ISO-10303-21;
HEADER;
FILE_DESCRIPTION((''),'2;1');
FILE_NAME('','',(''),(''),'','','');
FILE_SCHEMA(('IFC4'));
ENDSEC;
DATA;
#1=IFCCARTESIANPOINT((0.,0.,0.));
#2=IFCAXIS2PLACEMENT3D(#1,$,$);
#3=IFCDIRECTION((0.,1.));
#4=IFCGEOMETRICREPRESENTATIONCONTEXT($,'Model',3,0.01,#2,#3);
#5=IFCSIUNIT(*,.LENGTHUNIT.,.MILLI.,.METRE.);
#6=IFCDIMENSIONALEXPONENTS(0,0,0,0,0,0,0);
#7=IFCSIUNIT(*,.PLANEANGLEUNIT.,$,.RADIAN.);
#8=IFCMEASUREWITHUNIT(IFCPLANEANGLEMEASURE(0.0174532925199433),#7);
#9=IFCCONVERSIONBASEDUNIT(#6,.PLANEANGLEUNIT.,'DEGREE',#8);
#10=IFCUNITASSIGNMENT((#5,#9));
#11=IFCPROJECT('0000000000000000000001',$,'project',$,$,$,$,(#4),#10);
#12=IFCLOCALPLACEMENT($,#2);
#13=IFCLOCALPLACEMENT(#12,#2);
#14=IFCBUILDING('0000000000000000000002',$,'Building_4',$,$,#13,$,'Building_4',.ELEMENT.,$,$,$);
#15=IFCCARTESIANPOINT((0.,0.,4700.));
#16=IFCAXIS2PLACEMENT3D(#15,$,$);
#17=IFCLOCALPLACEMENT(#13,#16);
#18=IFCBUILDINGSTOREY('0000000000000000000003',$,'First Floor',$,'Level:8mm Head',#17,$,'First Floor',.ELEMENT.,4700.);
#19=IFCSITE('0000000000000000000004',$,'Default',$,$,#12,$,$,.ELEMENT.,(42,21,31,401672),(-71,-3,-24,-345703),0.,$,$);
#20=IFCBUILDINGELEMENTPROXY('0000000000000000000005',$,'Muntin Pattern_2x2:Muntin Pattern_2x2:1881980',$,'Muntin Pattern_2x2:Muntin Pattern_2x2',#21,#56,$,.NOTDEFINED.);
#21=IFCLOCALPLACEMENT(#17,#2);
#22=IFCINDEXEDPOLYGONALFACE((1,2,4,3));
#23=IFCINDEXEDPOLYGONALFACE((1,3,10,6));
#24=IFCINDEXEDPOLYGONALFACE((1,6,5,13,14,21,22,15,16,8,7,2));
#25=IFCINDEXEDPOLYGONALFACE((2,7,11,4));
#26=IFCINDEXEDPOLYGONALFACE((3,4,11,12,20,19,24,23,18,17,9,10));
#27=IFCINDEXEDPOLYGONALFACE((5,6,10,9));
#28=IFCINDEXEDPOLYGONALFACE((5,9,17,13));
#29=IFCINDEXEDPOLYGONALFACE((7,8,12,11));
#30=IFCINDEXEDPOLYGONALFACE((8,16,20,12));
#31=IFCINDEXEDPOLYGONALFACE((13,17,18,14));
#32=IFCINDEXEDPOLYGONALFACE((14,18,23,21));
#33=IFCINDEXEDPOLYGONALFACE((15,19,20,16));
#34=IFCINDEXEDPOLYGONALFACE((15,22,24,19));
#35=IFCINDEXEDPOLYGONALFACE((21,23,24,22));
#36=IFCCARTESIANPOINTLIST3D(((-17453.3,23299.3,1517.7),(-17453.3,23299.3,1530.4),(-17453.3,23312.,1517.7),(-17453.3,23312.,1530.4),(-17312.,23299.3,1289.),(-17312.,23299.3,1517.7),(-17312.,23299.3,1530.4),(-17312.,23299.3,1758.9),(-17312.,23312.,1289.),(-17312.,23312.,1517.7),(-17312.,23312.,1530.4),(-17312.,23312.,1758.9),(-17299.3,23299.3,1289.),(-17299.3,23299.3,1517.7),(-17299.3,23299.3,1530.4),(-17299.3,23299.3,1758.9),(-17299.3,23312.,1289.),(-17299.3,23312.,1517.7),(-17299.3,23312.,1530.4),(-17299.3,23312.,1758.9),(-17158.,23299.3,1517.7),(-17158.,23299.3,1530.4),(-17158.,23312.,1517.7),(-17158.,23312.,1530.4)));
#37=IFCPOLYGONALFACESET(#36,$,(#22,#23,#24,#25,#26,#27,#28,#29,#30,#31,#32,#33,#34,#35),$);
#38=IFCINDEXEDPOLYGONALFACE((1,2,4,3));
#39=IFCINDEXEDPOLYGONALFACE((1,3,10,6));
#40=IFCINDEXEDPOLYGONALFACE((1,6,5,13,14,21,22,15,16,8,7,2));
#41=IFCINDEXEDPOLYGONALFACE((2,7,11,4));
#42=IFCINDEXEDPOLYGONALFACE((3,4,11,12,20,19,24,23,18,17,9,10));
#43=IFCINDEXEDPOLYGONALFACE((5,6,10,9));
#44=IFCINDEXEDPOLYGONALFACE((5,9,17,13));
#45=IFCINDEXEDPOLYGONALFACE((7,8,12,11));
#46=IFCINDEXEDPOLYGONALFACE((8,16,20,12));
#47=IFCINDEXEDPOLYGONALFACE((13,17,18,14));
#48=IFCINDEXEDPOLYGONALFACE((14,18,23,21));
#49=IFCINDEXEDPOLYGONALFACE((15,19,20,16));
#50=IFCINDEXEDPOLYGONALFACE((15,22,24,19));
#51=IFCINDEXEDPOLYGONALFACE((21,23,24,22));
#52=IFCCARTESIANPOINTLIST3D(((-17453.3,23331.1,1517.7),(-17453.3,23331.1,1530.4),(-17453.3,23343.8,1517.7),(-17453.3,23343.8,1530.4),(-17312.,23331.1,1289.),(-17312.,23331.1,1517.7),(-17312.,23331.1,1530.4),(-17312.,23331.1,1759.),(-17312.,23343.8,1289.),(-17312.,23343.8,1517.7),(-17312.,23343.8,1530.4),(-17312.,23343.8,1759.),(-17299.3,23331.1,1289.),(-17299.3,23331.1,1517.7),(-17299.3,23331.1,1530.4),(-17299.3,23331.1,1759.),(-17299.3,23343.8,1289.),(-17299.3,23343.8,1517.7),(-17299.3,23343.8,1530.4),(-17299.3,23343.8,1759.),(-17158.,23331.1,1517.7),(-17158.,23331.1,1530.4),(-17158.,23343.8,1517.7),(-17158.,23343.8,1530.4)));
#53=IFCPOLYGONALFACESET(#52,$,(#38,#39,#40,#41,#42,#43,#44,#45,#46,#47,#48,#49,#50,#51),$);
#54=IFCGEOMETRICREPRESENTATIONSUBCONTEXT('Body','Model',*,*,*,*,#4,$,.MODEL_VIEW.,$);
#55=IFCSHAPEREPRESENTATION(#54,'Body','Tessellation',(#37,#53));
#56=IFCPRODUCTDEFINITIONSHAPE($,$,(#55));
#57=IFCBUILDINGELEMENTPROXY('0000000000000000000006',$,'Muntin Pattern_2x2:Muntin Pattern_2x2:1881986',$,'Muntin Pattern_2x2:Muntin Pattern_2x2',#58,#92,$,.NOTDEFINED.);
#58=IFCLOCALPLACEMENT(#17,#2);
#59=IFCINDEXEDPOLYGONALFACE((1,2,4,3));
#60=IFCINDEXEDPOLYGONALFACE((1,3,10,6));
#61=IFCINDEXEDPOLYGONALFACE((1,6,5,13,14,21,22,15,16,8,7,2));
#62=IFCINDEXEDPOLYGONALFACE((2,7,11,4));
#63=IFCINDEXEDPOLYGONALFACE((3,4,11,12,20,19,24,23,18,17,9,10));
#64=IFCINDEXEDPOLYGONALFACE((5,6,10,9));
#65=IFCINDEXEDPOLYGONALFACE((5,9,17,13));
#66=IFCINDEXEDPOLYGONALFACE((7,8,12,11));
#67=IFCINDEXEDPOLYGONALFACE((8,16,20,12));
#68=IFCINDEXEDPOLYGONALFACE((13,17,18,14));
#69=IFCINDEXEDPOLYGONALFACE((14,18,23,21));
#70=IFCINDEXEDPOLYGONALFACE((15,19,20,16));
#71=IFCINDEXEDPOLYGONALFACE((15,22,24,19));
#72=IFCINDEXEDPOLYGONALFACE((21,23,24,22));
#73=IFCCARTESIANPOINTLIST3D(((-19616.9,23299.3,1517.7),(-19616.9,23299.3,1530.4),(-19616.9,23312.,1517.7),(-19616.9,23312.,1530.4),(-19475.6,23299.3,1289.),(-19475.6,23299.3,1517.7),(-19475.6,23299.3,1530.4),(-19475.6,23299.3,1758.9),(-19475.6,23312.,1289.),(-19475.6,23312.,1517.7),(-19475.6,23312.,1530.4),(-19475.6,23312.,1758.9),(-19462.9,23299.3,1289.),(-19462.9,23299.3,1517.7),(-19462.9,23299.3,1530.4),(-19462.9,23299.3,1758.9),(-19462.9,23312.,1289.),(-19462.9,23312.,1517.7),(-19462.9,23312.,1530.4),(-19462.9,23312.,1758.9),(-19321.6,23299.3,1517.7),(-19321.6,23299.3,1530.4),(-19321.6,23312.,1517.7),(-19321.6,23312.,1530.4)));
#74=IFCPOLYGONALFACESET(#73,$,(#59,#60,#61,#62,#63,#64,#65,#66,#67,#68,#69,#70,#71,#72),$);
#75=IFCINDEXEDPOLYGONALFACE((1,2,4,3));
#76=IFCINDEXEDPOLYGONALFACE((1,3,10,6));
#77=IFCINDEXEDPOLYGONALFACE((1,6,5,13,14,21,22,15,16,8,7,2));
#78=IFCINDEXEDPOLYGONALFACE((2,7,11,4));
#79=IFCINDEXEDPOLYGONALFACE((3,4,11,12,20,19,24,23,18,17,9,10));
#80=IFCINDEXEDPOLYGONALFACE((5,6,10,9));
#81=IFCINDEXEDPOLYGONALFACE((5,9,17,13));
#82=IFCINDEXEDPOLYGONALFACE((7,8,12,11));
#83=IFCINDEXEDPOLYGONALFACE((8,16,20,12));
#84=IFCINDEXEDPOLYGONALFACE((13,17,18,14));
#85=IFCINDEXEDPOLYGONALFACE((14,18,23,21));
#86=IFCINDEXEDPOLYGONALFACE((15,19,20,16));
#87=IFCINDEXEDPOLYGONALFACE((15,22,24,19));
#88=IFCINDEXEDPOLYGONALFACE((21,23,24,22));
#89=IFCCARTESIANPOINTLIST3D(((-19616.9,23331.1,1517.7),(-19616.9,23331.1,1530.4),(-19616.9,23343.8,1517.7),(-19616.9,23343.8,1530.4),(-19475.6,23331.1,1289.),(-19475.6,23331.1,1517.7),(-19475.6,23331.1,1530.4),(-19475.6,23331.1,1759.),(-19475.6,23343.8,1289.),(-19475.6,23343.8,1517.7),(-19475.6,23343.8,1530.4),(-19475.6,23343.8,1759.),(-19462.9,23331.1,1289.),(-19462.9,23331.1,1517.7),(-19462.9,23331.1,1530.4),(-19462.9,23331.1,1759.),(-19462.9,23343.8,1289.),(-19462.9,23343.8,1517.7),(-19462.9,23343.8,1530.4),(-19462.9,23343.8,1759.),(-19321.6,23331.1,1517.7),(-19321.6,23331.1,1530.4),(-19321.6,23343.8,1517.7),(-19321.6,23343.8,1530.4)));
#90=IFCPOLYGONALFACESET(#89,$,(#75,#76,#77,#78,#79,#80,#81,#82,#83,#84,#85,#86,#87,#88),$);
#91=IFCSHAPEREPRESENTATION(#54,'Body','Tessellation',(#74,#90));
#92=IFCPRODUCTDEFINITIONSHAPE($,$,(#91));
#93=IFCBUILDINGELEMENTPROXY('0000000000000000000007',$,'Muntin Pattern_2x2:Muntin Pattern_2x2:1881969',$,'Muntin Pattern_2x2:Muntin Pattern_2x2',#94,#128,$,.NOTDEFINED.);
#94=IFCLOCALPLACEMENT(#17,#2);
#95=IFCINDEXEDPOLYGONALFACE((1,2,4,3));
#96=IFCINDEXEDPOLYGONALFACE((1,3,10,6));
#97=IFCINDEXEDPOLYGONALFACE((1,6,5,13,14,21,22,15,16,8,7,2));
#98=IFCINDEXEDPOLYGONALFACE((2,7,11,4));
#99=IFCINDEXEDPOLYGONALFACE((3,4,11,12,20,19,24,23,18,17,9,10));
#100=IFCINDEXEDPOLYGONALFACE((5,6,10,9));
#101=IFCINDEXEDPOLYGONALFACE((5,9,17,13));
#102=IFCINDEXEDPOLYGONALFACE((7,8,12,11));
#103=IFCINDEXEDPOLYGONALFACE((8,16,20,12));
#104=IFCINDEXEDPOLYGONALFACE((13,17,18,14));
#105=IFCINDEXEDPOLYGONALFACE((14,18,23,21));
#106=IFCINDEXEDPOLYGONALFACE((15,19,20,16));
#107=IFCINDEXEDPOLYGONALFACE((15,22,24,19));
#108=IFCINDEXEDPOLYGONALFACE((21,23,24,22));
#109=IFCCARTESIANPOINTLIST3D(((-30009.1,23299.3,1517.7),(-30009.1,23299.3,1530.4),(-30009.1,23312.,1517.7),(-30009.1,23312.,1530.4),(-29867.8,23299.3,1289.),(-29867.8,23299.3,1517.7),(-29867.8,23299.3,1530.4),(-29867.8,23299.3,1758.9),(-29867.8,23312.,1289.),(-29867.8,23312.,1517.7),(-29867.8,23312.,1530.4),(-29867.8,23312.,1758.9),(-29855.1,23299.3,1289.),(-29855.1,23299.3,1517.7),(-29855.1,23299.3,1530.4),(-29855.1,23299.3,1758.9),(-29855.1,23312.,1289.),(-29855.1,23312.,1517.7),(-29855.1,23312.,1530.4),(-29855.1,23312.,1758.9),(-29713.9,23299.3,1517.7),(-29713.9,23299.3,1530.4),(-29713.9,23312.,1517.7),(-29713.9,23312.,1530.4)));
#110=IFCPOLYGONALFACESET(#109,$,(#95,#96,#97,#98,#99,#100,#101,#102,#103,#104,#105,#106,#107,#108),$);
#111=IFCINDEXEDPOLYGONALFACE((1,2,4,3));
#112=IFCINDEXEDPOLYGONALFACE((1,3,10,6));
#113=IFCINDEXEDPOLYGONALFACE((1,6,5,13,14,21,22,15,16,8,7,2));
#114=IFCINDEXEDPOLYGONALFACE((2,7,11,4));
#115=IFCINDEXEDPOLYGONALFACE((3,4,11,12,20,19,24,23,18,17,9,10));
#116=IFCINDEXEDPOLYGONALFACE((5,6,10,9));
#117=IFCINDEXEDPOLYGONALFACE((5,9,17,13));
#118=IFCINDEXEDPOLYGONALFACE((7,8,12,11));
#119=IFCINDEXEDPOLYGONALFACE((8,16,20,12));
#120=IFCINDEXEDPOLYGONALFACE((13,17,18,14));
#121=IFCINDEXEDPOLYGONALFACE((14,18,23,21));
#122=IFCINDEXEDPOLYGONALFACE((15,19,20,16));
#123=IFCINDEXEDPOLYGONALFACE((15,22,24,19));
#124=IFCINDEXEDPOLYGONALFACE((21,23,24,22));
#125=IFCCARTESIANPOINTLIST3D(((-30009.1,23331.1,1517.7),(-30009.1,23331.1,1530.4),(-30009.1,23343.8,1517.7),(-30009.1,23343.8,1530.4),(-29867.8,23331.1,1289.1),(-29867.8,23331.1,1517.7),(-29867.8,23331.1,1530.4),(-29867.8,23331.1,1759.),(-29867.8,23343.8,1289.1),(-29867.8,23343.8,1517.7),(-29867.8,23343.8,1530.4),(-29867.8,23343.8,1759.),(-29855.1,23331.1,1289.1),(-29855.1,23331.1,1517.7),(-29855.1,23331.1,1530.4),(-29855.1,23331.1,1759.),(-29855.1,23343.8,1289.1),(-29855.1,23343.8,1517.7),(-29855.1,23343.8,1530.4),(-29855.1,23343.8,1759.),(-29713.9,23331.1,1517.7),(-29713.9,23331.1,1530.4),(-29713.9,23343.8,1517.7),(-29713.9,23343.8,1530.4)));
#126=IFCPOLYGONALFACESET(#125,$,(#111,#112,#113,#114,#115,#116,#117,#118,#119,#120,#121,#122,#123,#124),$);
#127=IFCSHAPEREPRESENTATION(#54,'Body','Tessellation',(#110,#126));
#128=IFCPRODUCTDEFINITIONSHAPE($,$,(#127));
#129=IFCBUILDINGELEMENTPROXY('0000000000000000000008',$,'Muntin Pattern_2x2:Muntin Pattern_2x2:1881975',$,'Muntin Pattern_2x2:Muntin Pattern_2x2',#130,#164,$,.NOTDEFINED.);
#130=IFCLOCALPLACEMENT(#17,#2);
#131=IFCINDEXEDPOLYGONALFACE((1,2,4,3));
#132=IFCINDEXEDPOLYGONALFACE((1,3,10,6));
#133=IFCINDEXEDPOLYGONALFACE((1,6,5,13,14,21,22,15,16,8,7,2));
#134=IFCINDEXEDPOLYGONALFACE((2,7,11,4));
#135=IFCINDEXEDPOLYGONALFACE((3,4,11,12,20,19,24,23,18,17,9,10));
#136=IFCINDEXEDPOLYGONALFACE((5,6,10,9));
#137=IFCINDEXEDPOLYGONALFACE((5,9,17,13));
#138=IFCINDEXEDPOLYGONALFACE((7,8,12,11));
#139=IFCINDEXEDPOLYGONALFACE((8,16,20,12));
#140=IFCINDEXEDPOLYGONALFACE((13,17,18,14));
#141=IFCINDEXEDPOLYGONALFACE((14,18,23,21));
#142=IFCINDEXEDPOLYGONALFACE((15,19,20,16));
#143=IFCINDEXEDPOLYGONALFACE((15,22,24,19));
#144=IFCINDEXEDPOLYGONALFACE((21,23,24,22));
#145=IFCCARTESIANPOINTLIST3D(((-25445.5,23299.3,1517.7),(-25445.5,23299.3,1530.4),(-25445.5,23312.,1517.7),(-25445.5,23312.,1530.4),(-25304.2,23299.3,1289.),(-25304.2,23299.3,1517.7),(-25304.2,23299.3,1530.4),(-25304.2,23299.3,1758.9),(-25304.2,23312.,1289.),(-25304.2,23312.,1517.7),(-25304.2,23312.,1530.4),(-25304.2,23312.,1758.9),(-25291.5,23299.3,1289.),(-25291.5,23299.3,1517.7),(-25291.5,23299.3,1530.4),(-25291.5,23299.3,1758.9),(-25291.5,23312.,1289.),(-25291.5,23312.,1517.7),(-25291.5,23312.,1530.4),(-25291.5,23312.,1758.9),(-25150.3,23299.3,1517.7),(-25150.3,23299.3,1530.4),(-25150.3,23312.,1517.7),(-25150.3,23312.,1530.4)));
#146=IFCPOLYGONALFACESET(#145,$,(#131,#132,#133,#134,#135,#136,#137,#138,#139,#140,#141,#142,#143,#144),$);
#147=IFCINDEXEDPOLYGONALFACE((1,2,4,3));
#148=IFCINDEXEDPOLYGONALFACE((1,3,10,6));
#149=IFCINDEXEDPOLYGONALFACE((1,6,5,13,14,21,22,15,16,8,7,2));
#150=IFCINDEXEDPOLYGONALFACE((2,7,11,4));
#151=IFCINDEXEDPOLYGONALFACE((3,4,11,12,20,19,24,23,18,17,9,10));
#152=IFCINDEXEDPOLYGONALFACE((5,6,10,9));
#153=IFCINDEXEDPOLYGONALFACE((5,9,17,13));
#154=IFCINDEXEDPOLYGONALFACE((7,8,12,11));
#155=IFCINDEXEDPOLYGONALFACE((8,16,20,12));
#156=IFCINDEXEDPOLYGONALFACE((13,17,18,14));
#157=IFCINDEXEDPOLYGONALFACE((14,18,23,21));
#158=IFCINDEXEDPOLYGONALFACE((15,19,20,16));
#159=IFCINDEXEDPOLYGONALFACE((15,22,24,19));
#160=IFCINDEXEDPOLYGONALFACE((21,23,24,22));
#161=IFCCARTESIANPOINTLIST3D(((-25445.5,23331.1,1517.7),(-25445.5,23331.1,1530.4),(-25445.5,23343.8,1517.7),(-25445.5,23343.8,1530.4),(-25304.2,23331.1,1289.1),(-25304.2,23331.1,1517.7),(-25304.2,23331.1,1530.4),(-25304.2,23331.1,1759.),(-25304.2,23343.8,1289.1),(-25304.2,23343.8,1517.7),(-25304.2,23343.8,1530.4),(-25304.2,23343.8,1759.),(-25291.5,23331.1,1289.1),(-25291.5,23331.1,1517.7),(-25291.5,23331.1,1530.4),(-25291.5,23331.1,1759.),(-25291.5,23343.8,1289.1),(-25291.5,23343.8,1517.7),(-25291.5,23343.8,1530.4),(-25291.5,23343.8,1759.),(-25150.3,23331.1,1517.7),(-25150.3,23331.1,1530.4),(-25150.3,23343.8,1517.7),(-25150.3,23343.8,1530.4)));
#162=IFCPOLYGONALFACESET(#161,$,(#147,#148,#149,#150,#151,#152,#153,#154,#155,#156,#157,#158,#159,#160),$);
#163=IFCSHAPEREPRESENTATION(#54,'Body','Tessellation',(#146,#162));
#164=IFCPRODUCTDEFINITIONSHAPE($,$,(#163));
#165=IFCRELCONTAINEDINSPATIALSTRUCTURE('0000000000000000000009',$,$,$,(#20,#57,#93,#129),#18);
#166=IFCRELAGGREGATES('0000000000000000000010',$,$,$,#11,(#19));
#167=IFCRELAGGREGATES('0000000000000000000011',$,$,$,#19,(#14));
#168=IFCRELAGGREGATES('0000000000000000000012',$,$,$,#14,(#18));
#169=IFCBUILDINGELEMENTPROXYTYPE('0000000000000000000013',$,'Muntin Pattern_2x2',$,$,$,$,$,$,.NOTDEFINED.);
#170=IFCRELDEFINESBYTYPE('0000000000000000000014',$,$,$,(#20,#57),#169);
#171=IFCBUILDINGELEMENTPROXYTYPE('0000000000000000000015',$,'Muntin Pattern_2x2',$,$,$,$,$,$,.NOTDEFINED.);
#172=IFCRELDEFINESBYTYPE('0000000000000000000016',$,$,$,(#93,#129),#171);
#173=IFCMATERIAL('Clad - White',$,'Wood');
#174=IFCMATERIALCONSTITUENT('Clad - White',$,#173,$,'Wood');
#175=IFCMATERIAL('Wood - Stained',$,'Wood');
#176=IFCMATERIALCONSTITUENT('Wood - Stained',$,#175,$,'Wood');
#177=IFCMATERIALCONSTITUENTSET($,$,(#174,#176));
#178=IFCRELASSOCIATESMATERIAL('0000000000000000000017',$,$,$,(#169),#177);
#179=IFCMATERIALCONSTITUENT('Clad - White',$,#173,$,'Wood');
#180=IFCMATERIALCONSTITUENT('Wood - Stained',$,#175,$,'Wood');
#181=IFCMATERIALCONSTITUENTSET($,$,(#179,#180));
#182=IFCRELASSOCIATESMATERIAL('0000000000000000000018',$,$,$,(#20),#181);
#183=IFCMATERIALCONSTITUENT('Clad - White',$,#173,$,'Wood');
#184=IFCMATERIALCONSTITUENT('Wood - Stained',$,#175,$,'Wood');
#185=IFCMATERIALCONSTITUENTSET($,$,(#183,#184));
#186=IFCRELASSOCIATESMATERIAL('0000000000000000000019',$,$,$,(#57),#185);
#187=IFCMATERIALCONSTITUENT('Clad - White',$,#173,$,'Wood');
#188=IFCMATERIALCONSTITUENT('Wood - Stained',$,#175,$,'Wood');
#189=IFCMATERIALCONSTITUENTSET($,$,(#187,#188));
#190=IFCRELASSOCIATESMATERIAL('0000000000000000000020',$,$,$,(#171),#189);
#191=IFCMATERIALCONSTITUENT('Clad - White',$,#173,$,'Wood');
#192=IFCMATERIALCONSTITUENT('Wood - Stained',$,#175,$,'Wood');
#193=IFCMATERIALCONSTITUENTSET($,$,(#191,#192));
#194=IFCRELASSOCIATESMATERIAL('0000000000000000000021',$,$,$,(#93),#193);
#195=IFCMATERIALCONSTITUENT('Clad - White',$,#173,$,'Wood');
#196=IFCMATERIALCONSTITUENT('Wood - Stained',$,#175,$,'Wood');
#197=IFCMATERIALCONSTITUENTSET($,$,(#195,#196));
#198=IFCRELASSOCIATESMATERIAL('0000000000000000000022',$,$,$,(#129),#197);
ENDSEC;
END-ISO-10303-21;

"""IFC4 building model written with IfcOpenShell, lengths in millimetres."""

from ifc_helpers import new_model, entity, si_unit, converted_unit, direction, frame, origin, place, context, subcontext, project, spatial, indexed_curve, outline, extrude, source, transform, mapped, material, constituent, constituent_set, type_object, type_shapes, element, save


model = new_model("IFC4")

# Units and contexts
model_context = context("Model", 3, precision=0.01, world=origin(), true_north=direction((0.0, 1.0)))
body_context = subcontext(model_context, "Body", "Model", "MODEL_VIEW")
ifc_project = project(units=[si_unit("LENGTHUNIT", "METRE", prefix="MILLI"), converted_unit("PLANEANGLEUNIT", "DEGREE", entity("IfcPlaneAngleMeasure", 0.0174532925199433), si_unit("PLANEANGLEUNIT", "RADIAN"), dimensions=[0, 0, 0, 0, 0, 0, 0])], contexts=[model_context])

# Site, building, storey
site_placement = place(None, origin())
site = spatial("IfcSite", under=ifc_project, at=site_placement, Name="Default", CompositionType="ELEMENT", RefLatitude=(42, 21, 31, 401672), RefLongitude=(-71, -3, -24, -345703), RefElevation=0.0)
building_placement = place(site_placement, origin())
building = spatial("IfcBuilding", under=site, at=building_placement, Name="Building_4", LongName="Building_4", CompositionType="ELEMENT")
storey_placement = place(building_placement, frame((0.0, 0.0, 4700.0)))
storey = spatial("IfcBuildingStorey", under=building, at=storey_placement, Name="First Floor", ObjectType="Level:8mm Head", LongName="First Floor", CompositionType="ELEMENT", Elevation=4700.0)

# Building element proxies
ifc_material_1 = material(Name="Clad - White", Category="Wood")
ifc_material_2 = material(Name="Wood - Stained", Category="Wood")
ifc_constituent_1 = constituent(ifc_material_1, Name="Clad - White", Category="Wood")
ifc_constituent_2 = constituent(ifc_material_2, Name="Wood - Stained", Category="Wood")
ifc_constituent_set_1 = constituent_set(constituents=[ifc_constituent_1, ifc_constituent_2])
building_element_proxy_type_1 = type_object("IfcBuildingElementProxyType", Name="Muntin Pattern_2x2", PredefinedType="NOTDEFINED", material=ifc_constituent_set_1)
shared_shape_1 = source(origin(), body_context, "Body", "SweptSolid", [
    extrude(outline(indexed_curve([(6.4, -6.4), (234.9, -6.4), (234.9, 6.3), (6.4, 6.3), (6.4, 147.6), (-6.3, 147.6), (-6.3, 6.3), (-235.0, 6.3), (-235.0, -6.4), (-6.3, -6.4), (-6.3, -147.6), (6.4, -147.6), (6.4, -6.4)], self_intersect=False)), frame((0.0, 9.5, 235.0), z_axis=(0.0, 1.0, 0.0), x_axis=(0.0, 0.0, 1.0)), (0.0, 0.0, 1.0), 12.7),
    extrude(outline(indexed_curve([(6.4, -6.4), (235.0, -6.4), (235.0, 6.3), (6.4, 6.3), (6.4, 147.6), (-6.3, 147.6), (-6.3, 6.3), (-235.0, 6.3), (-235.0, -6.4), (-6.3, -6.4), (-6.3, -147.6), (6.4, -147.6), (6.4, -6.4)], self_intersect=False)), frame((0.0, -22.2, 235.0), z_axis=(0.0, 1.0, 0.0), x_axis=(0.0, 0.0, 1.0)), (0.0, 0.0, 1.0), 12.7),
])
type_shapes(building_element_proxy_type_1, [shared_shape_1])
ifc_constituent_3 = constituent(ifc_material_1, Name="Clad - White", Category="Wood")
ifc_constituent_4 = constituent(ifc_material_2, Name="Wood - Stained", Category="Wood")
ifc_constituent_set_2 = constituent_set(constituents=[ifc_constituent_3, ifc_constituent_4])
proxy_1_placement = place(storey_placement, frame((-17305.7, 23321.5, 1289.0), z_axis=(0.0, 0.0, 1.0), x_axis=(-1.0, 0.0, 0.0)))
element("IfcBuildingElementProxy", 1, at=proxy_1_placement, inside=storey, type_object=building_element_proxy_type_1, material=ifc_constituent_set_2, Name="Muntin Pattern_2x2:Muntin Pattern_2x2:1881980", ObjectType="Muntin Pattern_2x2:Muntin Pattern_2x2", PredefinedType="NOTDEFINED", context=body_context, shape_type="MappedRepresentation", body=[
    mapped(shared_shape_1, transform((0.0, 0.0, 0.0), scale=1.0)),
])
ifc_constituent_5 = constituent(ifc_material_1, Name="Clad - White", Category="Wood")
ifc_constituent_6 = constituent(ifc_material_2, Name="Wood - Stained", Category="Wood")
ifc_constituent_set_3 = constituent_set(constituents=[ifc_constituent_5, ifc_constituent_6])
proxy_2_placement = place(storey_placement, frame((-19469.3, 23321.5, 1289.0), z_axis=(0.0, 0.0, 1.0), x_axis=(-1.0, 0.0, 0.0)))
element("IfcBuildingElementProxy", 2, at=proxy_2_placement, inside=storey, type_object=building_element_proxy_type_1, material=ifc_constituent_set_3, Name="Muntin Pattern_2x2:Muntin Pattern_2x2:1881986", ObjectType="Muntin Pattern_2x2:Muntin Pattern_2x2", PredefinedType="NOTDEFINED", context=body_context, shape_type="MappedRepresentation", body=[
    mapped(shared_shape_1, transform((0.0, 0.0, 0.0), scale=1.0)),
])
ifc_constituent_7 = constituent(ifc_material_1, Name="Clad - White", Category="Wood")
ifc_constituent_8 = constituent(ifc_material_2, Name="Wood - Stained", Category="Wood")
ifc_constituent_set_4 = constituent_set(constituents=[ifc_constituent_7, ifc_constituent_8])
ifc_constituent_9 = constituent(ifc_material_1, Name="Clad - White", Category="Wood")
ifc_constituent_10 = constituent(ifc_material_2, Name="Wood - Stained", Category="Wood")
ifc_constituent_set_5 = constituent_set(constituents=[ifc_constituent_9, ifc_constituent_10])
building_element_proxy_type_2 = type_object("IfcBuildingElementProxyType", Name="Muntin Pattern_2x2", PredefinedType="NOTDEFINED", material=ifc_constituent_set_5)
shared_shape_2 = source(origin(), body_context, "Body", "SweptSolid", [
    extrude(outline(indexed_curve([(6.4, -6.4), (234.9, -6.4), (234.9, 6.3), (6.4, 6.3), (6.4, 147.6), (-6.3, 147.6), (-6.3, 6.3), (-235.0, 6.3), (-235.0, -6.4), (-6.3, -6.4), (-6.3, -147.6), (6.4, -147.6), (6.4, -6.4)], self_intersect=False)), frame((0.0, -22.2, 234.9), z_axis=(0.0, 1.0, 0.0), x_axis=(0.0, 0.0, 1.0)), (0.0, 0.0, 1.0), 12.7),
    extrude(outline(indexed_curve([(6.4, -6.4), (235.0, -6.4), (235.0, 6.3), (6.4, 6.3), (6.4, 147.6), (-6.3, 147.6), (-6.3, 6.3), (-235.0, 6.3), (-235.0, -6.4), (-6.3, -6.4), (-6.3, -147.6), (6.4, -147.6), (6.4, -6.4)], self_intersect=False)), frame((0.0, 9.5, 235.0), z_axis=(0.0, 1.0, 0.0), x_axis=(0.0, 0.0, 1.0)), (0.0, 0.0, 1.0), 12.7),
])
type_shapes(building_element_proxy_type_2, [shared_shape_2])
proxy_3_placement = place(storey_placement, frame((-29861.5, 23321.5, 1289.1)))
element("IfcBuildingElementProxy", 3, at=proxy_3_placement, inside=storey, type_object=building_element_proxy_type_2, material=ifc_constituent_set_4, Name="Muntin Pattern_2x2:Muntin Pattern_2x2:1881969", ObjectType="Muntin Pattern_2x2:Muntin Pattern_2x2", PredefinedType="NOTDEFINED", context=body_context, shape_type="MappedRepresentation", body=[
    mapped(shared_shape_2, transform((0.0, 0.0, 0.0), scale=1.0)),
])
ifc_constituent_11 = constituent(ifc_material_1, Name="Clad - White", Category="Wood")
ifc_constituent_12 = constituent(ifc_material_2, Name="Wood - Stained", Category="Wood")
ifc_constituent_set_6 = constituent_set(constituents=[ifc_constituent_11, ifc_constituent_12])
proxy_4_placement = place(storey_placement, frame((-25297.9, 23321.5, 1289.1)))
element("IfcBuildingElementProxy", 4, at=proxy_4_placement, inside=storey, type_object=building_element_proxy_type_2, material=ifc_constituent_set_6, Name="Muntin Pattern_2x2:Muntin Pattern_2x2:1881975", ObjectType="Muntin Pattern_2x2:Muntin Pattern_2x2", PredefinedType="NOTDEFINED", context=body_context, shape_type="MappedRepresentation", body=[
    mapped(shared_shape_2, transform((0.0, 0.0, 0.0), scale=1.0)),
])

save(model, "model.ifc")
